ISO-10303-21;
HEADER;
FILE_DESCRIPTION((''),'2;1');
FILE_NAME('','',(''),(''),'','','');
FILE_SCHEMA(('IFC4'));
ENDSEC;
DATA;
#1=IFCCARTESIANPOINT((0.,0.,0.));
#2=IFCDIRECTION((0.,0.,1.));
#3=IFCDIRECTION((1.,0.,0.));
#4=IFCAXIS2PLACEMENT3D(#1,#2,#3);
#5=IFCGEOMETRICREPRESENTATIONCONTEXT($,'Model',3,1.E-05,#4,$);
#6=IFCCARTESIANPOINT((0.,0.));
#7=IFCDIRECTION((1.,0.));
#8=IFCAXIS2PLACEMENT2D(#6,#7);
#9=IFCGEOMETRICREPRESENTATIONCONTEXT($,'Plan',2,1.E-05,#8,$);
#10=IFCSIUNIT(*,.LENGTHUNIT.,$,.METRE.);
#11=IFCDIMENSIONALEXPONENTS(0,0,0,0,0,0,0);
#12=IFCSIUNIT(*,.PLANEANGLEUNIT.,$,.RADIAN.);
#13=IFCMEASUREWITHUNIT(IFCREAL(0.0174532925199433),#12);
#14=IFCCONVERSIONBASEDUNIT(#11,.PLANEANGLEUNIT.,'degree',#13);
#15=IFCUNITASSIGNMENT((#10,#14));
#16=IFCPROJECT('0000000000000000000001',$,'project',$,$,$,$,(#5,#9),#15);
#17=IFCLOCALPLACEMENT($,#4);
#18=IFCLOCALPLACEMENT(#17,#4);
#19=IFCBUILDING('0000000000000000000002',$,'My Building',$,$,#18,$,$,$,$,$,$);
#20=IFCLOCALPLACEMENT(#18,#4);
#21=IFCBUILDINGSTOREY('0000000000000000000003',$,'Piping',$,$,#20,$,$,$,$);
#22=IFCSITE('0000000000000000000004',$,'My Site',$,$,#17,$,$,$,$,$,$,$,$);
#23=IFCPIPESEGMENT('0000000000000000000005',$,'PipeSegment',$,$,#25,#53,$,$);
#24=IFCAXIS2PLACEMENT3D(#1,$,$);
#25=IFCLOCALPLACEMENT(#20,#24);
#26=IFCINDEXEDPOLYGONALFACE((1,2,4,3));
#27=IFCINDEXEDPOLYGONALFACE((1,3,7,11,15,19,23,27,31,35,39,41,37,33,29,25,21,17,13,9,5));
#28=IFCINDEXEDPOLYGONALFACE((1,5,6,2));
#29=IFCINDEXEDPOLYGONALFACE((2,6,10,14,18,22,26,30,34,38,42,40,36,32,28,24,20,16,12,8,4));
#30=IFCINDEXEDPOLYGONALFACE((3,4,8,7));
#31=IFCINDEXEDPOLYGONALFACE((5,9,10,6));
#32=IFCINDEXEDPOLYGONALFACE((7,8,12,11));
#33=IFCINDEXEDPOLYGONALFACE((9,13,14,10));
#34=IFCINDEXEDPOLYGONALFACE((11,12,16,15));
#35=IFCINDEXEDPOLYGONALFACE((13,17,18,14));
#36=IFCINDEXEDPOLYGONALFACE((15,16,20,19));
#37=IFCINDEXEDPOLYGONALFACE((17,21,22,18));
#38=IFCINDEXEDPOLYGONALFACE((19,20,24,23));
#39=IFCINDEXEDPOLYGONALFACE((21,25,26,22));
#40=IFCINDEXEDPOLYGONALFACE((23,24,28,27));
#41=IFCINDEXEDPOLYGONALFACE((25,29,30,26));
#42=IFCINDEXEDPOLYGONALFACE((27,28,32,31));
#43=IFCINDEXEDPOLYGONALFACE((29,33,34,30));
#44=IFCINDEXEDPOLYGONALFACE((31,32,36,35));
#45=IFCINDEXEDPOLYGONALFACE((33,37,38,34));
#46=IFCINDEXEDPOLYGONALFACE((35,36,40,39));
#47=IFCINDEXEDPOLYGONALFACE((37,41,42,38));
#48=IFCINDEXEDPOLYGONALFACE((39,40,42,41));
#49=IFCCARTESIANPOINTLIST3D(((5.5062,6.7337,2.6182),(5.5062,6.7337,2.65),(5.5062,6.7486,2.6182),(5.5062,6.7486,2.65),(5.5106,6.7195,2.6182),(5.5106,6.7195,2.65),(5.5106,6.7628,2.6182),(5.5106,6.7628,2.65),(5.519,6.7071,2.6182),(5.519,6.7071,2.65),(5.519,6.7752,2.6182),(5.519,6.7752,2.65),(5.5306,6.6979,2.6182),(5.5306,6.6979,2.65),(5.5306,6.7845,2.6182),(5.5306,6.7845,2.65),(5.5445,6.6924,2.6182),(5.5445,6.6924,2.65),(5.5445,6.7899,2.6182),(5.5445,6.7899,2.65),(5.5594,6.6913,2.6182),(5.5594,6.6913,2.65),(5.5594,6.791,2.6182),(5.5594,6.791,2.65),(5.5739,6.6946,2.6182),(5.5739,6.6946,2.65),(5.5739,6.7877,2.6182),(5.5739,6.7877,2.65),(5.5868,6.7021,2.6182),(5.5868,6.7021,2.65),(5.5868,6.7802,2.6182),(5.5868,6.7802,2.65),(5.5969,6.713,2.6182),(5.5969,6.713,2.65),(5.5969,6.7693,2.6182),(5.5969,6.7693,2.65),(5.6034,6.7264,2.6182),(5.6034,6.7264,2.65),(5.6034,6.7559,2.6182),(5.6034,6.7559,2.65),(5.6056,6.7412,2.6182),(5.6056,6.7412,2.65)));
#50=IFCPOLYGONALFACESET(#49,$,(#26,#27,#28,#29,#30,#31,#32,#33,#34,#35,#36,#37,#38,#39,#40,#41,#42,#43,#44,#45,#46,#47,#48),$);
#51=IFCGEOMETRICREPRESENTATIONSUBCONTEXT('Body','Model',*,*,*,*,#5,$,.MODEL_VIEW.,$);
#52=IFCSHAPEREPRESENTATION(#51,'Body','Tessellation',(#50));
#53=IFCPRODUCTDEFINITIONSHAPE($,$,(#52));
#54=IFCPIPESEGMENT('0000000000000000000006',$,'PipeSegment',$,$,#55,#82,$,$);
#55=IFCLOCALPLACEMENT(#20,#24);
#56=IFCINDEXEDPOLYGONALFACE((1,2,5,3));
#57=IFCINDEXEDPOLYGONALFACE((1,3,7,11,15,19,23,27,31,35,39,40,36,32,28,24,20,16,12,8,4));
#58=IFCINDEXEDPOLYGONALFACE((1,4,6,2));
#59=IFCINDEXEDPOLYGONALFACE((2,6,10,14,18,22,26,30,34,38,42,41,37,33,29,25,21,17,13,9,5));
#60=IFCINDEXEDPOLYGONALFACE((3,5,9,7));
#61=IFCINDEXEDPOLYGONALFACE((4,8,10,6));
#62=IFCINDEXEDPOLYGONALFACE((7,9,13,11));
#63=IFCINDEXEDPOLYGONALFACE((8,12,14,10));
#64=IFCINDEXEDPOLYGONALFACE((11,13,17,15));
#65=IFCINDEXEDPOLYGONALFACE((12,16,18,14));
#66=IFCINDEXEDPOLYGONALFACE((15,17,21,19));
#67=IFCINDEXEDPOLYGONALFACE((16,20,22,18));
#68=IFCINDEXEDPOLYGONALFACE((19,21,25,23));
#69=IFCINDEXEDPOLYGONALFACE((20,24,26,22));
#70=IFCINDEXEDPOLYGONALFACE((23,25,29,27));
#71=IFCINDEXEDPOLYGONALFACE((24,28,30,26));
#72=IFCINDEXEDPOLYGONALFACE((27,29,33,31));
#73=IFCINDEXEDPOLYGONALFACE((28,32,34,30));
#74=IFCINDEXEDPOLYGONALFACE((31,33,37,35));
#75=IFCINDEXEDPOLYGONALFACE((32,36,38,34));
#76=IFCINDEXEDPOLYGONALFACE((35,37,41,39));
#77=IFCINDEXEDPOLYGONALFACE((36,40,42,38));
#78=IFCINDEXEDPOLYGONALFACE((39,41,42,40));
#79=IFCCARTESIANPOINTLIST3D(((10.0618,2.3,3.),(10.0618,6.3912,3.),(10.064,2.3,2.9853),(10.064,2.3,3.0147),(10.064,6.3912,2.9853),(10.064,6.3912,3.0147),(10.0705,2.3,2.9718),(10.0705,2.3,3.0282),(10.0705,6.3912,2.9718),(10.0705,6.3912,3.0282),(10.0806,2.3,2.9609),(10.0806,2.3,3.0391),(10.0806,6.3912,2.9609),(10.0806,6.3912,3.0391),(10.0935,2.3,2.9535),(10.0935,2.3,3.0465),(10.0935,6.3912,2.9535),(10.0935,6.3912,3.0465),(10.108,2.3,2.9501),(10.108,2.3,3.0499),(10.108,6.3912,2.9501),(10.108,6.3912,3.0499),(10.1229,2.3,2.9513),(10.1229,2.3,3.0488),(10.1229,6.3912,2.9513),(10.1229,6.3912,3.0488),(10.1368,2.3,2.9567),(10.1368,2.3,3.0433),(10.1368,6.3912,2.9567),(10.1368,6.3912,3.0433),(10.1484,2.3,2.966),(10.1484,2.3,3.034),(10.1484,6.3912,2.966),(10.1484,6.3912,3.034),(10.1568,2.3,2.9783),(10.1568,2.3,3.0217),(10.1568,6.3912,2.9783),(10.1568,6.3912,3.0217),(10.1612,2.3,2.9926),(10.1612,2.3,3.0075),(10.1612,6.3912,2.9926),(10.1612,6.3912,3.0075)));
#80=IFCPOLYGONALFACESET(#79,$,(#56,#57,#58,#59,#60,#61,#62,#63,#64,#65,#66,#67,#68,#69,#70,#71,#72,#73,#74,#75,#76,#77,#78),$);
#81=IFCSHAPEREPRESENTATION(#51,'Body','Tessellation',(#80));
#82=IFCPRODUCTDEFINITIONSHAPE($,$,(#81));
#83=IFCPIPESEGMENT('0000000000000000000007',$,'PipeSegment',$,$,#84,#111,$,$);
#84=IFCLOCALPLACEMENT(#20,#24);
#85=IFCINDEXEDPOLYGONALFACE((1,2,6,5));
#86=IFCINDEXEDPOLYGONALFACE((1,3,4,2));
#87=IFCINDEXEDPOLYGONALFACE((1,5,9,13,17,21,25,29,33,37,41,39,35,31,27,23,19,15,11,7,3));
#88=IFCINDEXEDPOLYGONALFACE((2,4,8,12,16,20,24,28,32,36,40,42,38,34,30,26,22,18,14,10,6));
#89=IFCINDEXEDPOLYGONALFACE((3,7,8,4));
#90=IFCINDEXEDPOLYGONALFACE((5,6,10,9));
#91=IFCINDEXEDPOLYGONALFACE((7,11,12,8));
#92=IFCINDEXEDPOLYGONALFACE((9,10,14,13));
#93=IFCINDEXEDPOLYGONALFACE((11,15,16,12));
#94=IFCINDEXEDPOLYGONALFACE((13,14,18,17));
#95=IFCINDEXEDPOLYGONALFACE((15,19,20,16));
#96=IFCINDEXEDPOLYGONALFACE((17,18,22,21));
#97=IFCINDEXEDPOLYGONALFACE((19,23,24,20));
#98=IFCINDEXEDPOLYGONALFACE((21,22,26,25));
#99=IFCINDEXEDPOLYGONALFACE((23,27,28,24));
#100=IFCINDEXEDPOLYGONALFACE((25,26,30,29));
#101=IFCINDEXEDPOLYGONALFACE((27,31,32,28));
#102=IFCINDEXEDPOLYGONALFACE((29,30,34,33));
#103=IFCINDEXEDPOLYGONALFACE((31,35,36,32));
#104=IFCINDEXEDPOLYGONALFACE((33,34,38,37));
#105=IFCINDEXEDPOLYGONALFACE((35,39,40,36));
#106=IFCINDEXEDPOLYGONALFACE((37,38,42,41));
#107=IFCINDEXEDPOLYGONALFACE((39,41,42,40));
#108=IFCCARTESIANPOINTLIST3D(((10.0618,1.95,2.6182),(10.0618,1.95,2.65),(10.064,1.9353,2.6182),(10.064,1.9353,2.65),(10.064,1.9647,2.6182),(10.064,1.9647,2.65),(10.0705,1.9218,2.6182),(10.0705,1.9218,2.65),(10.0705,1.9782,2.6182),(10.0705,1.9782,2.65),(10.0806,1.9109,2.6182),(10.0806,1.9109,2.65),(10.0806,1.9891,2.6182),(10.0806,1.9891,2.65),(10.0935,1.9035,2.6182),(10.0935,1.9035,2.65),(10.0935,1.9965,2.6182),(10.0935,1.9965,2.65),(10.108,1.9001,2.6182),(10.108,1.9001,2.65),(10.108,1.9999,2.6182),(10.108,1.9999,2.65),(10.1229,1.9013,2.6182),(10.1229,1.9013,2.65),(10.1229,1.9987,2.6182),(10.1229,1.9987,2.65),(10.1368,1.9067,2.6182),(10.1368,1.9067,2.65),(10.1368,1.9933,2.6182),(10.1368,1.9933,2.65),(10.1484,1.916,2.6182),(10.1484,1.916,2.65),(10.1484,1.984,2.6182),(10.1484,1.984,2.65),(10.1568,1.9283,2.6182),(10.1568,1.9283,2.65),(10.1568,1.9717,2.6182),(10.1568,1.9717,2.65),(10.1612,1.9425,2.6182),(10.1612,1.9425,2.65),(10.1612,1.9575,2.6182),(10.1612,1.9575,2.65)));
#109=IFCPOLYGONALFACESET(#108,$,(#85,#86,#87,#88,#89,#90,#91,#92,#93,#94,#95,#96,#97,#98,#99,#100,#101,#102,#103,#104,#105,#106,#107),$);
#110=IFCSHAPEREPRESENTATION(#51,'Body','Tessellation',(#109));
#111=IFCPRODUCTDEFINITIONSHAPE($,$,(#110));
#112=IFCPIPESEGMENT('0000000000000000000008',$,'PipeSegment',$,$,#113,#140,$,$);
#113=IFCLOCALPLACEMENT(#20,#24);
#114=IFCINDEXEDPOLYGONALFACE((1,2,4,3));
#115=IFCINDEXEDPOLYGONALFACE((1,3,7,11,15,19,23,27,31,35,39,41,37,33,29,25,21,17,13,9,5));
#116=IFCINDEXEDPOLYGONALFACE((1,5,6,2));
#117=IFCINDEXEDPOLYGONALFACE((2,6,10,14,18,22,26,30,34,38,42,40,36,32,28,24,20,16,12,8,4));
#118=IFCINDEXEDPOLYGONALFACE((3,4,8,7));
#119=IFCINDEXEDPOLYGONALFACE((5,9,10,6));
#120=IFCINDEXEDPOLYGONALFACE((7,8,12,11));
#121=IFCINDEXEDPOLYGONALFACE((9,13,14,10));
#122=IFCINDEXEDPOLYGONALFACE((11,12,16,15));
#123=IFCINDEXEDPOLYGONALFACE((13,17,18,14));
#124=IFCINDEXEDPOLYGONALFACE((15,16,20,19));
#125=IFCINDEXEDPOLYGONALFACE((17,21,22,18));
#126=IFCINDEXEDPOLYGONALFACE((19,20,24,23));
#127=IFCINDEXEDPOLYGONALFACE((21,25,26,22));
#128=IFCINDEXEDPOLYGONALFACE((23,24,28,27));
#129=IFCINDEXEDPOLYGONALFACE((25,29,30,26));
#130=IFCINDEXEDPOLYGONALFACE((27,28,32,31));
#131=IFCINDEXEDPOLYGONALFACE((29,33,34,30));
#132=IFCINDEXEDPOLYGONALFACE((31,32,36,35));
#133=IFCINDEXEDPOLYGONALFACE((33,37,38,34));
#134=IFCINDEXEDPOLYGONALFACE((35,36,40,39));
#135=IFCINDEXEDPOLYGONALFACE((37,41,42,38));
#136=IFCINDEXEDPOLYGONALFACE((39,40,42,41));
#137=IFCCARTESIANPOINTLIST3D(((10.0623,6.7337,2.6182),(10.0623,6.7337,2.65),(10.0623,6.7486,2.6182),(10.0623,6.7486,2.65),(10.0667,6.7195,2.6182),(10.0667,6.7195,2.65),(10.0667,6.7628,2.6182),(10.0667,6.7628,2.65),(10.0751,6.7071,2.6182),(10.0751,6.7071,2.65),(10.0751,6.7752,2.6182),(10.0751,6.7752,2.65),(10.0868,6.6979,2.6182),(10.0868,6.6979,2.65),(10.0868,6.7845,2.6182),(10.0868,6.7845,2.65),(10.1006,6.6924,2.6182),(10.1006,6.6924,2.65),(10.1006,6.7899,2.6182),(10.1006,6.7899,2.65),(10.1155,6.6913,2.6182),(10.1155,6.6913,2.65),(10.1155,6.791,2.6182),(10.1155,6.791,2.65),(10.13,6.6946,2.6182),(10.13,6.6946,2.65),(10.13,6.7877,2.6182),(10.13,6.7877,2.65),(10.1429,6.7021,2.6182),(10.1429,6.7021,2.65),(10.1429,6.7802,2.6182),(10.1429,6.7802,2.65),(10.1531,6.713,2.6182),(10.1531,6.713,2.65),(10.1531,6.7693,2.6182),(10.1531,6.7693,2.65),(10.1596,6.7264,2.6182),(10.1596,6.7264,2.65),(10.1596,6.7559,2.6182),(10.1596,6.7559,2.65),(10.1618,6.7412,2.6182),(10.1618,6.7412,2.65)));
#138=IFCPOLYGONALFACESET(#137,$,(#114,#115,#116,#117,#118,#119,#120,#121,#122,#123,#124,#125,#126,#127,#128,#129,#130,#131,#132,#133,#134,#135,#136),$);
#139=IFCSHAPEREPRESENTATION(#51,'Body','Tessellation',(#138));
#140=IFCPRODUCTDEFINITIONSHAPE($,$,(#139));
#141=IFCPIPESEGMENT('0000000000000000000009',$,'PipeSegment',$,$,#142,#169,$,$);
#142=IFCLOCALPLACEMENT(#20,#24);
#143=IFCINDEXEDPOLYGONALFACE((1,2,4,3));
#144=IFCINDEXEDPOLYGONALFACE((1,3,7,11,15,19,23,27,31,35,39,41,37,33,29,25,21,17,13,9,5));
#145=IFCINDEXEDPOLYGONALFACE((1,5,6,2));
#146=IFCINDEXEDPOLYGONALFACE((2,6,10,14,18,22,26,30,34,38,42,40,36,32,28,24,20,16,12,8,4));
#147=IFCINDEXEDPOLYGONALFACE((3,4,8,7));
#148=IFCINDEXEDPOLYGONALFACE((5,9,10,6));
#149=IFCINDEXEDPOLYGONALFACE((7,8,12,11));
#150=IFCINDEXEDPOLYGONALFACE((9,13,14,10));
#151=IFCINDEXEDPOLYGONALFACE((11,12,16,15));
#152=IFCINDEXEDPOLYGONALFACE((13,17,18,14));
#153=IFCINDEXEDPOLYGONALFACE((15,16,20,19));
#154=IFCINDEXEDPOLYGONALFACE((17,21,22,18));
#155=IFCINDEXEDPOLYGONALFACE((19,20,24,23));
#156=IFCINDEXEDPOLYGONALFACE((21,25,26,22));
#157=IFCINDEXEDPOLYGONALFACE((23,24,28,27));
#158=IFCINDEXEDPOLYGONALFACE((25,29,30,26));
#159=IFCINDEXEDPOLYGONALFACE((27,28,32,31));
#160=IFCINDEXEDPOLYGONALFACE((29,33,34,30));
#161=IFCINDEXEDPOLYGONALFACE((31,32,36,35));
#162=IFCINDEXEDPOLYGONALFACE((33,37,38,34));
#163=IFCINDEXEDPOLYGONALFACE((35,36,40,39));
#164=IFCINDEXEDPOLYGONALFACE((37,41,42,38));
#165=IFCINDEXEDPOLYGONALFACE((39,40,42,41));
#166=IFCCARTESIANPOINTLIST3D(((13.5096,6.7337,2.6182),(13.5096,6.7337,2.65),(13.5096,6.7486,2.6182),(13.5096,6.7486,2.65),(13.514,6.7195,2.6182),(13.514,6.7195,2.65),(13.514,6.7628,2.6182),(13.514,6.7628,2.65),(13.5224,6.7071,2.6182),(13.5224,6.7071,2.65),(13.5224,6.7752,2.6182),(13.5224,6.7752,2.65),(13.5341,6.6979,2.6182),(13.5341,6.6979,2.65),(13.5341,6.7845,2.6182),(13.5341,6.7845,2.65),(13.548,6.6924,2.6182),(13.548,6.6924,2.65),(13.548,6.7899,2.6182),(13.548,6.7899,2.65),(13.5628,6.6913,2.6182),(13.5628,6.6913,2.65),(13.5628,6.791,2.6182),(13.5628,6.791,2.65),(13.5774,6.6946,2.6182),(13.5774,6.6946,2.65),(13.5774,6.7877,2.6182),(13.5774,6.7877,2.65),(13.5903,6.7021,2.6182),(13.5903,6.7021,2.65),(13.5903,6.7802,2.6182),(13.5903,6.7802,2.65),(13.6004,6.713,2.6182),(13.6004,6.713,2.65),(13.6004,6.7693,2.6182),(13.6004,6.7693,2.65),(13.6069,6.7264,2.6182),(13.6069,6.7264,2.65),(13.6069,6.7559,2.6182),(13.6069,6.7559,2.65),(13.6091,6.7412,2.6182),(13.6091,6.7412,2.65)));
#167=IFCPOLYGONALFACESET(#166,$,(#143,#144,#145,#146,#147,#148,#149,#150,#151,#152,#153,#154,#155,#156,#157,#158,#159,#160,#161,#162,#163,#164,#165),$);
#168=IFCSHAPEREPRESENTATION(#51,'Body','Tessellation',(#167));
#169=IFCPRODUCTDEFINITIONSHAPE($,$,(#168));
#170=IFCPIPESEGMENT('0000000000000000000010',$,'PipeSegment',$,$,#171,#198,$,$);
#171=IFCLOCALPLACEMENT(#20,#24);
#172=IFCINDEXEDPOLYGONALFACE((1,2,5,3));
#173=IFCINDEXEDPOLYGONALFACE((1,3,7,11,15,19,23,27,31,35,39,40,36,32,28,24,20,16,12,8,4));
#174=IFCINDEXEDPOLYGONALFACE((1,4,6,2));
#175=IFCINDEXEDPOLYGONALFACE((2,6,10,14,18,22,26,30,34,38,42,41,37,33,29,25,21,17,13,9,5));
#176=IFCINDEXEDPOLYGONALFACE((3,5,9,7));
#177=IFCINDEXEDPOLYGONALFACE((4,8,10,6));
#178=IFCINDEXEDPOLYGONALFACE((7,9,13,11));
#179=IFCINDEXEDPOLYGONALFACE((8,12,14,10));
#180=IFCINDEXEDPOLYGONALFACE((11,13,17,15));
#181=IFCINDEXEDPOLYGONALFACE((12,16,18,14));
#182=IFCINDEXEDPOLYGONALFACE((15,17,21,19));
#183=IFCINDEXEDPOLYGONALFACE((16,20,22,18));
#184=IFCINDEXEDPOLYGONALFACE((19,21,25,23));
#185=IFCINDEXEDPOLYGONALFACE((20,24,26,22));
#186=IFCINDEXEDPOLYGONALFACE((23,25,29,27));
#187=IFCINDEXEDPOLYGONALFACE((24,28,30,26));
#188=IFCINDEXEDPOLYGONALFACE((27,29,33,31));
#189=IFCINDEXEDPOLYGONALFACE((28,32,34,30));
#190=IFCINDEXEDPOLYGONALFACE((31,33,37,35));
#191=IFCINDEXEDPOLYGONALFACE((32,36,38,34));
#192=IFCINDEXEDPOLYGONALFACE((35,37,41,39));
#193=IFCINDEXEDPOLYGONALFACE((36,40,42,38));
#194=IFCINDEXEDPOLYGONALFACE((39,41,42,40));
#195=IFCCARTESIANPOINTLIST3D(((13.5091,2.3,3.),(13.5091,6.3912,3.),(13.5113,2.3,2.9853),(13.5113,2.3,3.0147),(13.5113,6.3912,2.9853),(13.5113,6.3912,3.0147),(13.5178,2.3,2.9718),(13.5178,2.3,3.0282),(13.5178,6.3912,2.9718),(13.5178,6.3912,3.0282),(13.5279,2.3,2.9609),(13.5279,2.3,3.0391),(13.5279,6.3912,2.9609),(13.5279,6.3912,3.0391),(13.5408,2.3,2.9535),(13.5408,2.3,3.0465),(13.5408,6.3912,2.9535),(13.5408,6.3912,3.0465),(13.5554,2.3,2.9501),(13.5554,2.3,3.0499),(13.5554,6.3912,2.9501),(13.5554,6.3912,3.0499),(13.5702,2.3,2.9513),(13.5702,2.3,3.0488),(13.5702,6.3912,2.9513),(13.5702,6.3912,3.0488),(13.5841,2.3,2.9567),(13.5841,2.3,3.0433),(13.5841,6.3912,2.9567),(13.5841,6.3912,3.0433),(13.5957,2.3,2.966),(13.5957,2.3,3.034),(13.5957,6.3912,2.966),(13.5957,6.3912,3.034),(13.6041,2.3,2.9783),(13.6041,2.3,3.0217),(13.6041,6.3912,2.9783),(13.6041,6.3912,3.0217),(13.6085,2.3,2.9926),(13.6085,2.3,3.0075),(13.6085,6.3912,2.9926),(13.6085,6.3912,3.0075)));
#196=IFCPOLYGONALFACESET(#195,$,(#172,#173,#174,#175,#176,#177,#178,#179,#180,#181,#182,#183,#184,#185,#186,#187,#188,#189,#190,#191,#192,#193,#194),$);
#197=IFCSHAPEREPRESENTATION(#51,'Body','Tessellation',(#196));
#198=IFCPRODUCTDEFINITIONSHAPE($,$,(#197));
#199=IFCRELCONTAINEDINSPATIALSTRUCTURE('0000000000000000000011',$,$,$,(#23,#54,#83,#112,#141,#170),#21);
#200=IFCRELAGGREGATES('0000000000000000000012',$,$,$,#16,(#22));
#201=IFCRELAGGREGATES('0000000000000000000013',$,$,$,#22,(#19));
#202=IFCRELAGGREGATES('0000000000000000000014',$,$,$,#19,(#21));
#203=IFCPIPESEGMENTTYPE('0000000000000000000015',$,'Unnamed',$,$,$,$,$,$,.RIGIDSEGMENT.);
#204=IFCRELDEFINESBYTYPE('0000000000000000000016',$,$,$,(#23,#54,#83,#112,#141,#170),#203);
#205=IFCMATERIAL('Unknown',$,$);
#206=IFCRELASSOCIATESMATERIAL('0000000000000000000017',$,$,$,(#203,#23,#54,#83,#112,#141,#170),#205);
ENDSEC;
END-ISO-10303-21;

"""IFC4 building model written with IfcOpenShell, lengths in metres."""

from ifc_helpers import new_model, entity, si_unit, converted_unit, frame, origin_with_axes, origin_2d_with_axis, place, context, subcontext, project, spatial, circle, extrude, material, material_profile, profile_set, profile_usage, type_object, element, save


model = new_model("IFC4")

# Units and contexts
model_context = context("Model", 3, precision=1e-05, world=origin_with_axes())
plan_context = context("Plan", 2, precision=1e-05, world=origin_2d_with_axis())
body_context = subcontext(model_context, "Body", "Model", "MODEL_VIEW")
ifc_project = project(units=[si_unit("LENGTHUNIT", "METRE"), converted_unit("PLANEANGLEUNIT", "degree", entity("IfcReal", 0.0174532925199433), si_unit("PLANEANGLEUNIT", "RADIAN"), dimensions=[0, 0, 0, 0, 0, 0, 0])], contexts=[model_context, plan_context])

# Site, building, storey
site_placement = place(None, origin_with_axes())
site = spatial("IfcSite", under=ifc_project, at=site_placement, Name="My Site")
building_placement = place(site_placement, origin_with_axes())
building = spatial("IfcBuilding", under=site, at=building_placement, Name="My Building")
storey_placement = place(building_placement, origin_with_axes())
storey = spatial("IfcBuildingStorey", under=building, at=storey_placement, Name="Piping")

# Pipe segments
ifc_material = material(Name="Unknown")
ifc_material_profile = material_profile(ifc_material, circle(Radius=0.05))
ifc_profile_set = profile_set([ifc_material_profile])
pipe_segment_type = type_object("IfcPipeSegmentType", Name="Unnamed", PredefinedType="RIGIDSEGMENT", material=ifc_profile_set)
ifc_profile_usage_1 = profile_usage(ifc_profile_set, cardinal=5)
pipe_segment_1_placement = place(storey_placement, frame((5.5556, 6.7412, 2.65), z_axis=(0.0, 0.0, -1.0), x_axis=(1.0, 0.0, 0.0)))
element("IfcPipeSegment", 1, at=pipe_segment_1_placement, inside=storey, type_object=pipe_segment_type, material=ifc_profile_usage_1, Name="PipeSegment", context=body_context, shape_type="SweptSolid", body=[
    extrude(circle(Radius=0.05), origin_with_axes(), (0.0, 0.0, 1.0), 0.0318),
])
ifc_profile_usage_2 = profile_usage(ifc_profile_set, cardinal=5)
pipe_segment_2_placement = place(storey_placement, frame((10.1118, 2.3, 3.0), z_axis=(0.0, 1.0, 0.0), x_axis=(-1.0, 0.0, 0.0)))
element("IfcPipeSegment", 2, at=pipe_segment_2_placement, inside=storey, type_object=pipe_segment_type, material=ifc_profile_usage_2, Name="PipeSegment", context=body_context, shape_type="SweptSolid", body=[
    extrude(circle(Radius=0.05), origin_with_axes(), (0.0, 0.0, 1.0), 4.0912),
])
ifc_profile_usage_3 = profile_usage(ifc_profile_set, cardinal=5)
pipe_segment_3_placement = place(storey_placement, frame((10.1118, 1.95, 2.65), z_axis=(0.0, 0.0, -1.0), x_axis=(-1.0, 0.0, 0.0)))
element("IfcPipeSegment", 3, at=pipe_segment_3_placement, inside=storey, type_object=pipe_segment_type, material=ifc_profile_usage_3, Name="PipeSegment", context=body_context, shape_type="SweptSolid", body=[
    extrude(circle(Radius=0.05), origin_with_axes(), (0.0, 0.0, 1.0), 0.0318),
])
ifc_profile_usage_4 = profile_usage(ifc_profile_set, cardinal=5)
pipe_segment_4_placement = place(storey_placement, frame((10.1118, 6.7412, 2.65), z_axis=(0.0, 0.0, -1.0), x_axis=(1.0, 0.0, 0.0)))
element("IfcPipeSegment", 4, at=pipe_segment_4_placement, inside=storey, type_object=pipe_segment_type, material=ifc_profile_usage_4, Name="PipeSegment", context=body_context, shape_type="SweptSolid", body=[
    extrude(circle(Radius=0.05), origin_with_axes(), (0.0, 0.0, 1.0), 0.0318),
])
ifc_profile_usage_5 = profile_usage(ifc_profile_set, cardinal=5)
pipe_segment_5_placement = place(storey_placement, frame((13.5591, 6.7412, 2.65), z_axis=(0.0, 0.0, -1.0), x_axis=(1.0, 0.0, 0.0)))
element("IfcPipeSegment", 5, at=pipe_segment_5_placement, inside=storey, type_object=pipe_segment_type, material=ifc_profile_usage_5, Name="PipeSegment", context=body_context, shape_type="SweptSolid", body=[
    extrude(circle(Radius=0.05), origin_with_axes(), (0.0, 0.0, 1.0), 0.0318),
])
ifc_profile_usage_6 = profile_usage(ifc_profile_set, cardinal=5)
pipe_segment_6_placement = place(storey_placement, frame((13.5591, 2.3, 3.0), z_axis=(0.0, 1.0, 0.0), x_axis=(-1.0, 0.0, 0.0)))
element("IfcPipeSegment", 6, at=pipe_segment_6_placement, inside=storey, type_object=pipe_segment_type, material=ifc_profile_usage_6, Name="PipeSegment", context=body_context, shape_type="SweptSolid", body=[
    extrude(circle(Radius=0.05), origin_with_axes(), (0.0, 0.0, 1.0), 4.0912),
])

save(model, "model.ifc")
